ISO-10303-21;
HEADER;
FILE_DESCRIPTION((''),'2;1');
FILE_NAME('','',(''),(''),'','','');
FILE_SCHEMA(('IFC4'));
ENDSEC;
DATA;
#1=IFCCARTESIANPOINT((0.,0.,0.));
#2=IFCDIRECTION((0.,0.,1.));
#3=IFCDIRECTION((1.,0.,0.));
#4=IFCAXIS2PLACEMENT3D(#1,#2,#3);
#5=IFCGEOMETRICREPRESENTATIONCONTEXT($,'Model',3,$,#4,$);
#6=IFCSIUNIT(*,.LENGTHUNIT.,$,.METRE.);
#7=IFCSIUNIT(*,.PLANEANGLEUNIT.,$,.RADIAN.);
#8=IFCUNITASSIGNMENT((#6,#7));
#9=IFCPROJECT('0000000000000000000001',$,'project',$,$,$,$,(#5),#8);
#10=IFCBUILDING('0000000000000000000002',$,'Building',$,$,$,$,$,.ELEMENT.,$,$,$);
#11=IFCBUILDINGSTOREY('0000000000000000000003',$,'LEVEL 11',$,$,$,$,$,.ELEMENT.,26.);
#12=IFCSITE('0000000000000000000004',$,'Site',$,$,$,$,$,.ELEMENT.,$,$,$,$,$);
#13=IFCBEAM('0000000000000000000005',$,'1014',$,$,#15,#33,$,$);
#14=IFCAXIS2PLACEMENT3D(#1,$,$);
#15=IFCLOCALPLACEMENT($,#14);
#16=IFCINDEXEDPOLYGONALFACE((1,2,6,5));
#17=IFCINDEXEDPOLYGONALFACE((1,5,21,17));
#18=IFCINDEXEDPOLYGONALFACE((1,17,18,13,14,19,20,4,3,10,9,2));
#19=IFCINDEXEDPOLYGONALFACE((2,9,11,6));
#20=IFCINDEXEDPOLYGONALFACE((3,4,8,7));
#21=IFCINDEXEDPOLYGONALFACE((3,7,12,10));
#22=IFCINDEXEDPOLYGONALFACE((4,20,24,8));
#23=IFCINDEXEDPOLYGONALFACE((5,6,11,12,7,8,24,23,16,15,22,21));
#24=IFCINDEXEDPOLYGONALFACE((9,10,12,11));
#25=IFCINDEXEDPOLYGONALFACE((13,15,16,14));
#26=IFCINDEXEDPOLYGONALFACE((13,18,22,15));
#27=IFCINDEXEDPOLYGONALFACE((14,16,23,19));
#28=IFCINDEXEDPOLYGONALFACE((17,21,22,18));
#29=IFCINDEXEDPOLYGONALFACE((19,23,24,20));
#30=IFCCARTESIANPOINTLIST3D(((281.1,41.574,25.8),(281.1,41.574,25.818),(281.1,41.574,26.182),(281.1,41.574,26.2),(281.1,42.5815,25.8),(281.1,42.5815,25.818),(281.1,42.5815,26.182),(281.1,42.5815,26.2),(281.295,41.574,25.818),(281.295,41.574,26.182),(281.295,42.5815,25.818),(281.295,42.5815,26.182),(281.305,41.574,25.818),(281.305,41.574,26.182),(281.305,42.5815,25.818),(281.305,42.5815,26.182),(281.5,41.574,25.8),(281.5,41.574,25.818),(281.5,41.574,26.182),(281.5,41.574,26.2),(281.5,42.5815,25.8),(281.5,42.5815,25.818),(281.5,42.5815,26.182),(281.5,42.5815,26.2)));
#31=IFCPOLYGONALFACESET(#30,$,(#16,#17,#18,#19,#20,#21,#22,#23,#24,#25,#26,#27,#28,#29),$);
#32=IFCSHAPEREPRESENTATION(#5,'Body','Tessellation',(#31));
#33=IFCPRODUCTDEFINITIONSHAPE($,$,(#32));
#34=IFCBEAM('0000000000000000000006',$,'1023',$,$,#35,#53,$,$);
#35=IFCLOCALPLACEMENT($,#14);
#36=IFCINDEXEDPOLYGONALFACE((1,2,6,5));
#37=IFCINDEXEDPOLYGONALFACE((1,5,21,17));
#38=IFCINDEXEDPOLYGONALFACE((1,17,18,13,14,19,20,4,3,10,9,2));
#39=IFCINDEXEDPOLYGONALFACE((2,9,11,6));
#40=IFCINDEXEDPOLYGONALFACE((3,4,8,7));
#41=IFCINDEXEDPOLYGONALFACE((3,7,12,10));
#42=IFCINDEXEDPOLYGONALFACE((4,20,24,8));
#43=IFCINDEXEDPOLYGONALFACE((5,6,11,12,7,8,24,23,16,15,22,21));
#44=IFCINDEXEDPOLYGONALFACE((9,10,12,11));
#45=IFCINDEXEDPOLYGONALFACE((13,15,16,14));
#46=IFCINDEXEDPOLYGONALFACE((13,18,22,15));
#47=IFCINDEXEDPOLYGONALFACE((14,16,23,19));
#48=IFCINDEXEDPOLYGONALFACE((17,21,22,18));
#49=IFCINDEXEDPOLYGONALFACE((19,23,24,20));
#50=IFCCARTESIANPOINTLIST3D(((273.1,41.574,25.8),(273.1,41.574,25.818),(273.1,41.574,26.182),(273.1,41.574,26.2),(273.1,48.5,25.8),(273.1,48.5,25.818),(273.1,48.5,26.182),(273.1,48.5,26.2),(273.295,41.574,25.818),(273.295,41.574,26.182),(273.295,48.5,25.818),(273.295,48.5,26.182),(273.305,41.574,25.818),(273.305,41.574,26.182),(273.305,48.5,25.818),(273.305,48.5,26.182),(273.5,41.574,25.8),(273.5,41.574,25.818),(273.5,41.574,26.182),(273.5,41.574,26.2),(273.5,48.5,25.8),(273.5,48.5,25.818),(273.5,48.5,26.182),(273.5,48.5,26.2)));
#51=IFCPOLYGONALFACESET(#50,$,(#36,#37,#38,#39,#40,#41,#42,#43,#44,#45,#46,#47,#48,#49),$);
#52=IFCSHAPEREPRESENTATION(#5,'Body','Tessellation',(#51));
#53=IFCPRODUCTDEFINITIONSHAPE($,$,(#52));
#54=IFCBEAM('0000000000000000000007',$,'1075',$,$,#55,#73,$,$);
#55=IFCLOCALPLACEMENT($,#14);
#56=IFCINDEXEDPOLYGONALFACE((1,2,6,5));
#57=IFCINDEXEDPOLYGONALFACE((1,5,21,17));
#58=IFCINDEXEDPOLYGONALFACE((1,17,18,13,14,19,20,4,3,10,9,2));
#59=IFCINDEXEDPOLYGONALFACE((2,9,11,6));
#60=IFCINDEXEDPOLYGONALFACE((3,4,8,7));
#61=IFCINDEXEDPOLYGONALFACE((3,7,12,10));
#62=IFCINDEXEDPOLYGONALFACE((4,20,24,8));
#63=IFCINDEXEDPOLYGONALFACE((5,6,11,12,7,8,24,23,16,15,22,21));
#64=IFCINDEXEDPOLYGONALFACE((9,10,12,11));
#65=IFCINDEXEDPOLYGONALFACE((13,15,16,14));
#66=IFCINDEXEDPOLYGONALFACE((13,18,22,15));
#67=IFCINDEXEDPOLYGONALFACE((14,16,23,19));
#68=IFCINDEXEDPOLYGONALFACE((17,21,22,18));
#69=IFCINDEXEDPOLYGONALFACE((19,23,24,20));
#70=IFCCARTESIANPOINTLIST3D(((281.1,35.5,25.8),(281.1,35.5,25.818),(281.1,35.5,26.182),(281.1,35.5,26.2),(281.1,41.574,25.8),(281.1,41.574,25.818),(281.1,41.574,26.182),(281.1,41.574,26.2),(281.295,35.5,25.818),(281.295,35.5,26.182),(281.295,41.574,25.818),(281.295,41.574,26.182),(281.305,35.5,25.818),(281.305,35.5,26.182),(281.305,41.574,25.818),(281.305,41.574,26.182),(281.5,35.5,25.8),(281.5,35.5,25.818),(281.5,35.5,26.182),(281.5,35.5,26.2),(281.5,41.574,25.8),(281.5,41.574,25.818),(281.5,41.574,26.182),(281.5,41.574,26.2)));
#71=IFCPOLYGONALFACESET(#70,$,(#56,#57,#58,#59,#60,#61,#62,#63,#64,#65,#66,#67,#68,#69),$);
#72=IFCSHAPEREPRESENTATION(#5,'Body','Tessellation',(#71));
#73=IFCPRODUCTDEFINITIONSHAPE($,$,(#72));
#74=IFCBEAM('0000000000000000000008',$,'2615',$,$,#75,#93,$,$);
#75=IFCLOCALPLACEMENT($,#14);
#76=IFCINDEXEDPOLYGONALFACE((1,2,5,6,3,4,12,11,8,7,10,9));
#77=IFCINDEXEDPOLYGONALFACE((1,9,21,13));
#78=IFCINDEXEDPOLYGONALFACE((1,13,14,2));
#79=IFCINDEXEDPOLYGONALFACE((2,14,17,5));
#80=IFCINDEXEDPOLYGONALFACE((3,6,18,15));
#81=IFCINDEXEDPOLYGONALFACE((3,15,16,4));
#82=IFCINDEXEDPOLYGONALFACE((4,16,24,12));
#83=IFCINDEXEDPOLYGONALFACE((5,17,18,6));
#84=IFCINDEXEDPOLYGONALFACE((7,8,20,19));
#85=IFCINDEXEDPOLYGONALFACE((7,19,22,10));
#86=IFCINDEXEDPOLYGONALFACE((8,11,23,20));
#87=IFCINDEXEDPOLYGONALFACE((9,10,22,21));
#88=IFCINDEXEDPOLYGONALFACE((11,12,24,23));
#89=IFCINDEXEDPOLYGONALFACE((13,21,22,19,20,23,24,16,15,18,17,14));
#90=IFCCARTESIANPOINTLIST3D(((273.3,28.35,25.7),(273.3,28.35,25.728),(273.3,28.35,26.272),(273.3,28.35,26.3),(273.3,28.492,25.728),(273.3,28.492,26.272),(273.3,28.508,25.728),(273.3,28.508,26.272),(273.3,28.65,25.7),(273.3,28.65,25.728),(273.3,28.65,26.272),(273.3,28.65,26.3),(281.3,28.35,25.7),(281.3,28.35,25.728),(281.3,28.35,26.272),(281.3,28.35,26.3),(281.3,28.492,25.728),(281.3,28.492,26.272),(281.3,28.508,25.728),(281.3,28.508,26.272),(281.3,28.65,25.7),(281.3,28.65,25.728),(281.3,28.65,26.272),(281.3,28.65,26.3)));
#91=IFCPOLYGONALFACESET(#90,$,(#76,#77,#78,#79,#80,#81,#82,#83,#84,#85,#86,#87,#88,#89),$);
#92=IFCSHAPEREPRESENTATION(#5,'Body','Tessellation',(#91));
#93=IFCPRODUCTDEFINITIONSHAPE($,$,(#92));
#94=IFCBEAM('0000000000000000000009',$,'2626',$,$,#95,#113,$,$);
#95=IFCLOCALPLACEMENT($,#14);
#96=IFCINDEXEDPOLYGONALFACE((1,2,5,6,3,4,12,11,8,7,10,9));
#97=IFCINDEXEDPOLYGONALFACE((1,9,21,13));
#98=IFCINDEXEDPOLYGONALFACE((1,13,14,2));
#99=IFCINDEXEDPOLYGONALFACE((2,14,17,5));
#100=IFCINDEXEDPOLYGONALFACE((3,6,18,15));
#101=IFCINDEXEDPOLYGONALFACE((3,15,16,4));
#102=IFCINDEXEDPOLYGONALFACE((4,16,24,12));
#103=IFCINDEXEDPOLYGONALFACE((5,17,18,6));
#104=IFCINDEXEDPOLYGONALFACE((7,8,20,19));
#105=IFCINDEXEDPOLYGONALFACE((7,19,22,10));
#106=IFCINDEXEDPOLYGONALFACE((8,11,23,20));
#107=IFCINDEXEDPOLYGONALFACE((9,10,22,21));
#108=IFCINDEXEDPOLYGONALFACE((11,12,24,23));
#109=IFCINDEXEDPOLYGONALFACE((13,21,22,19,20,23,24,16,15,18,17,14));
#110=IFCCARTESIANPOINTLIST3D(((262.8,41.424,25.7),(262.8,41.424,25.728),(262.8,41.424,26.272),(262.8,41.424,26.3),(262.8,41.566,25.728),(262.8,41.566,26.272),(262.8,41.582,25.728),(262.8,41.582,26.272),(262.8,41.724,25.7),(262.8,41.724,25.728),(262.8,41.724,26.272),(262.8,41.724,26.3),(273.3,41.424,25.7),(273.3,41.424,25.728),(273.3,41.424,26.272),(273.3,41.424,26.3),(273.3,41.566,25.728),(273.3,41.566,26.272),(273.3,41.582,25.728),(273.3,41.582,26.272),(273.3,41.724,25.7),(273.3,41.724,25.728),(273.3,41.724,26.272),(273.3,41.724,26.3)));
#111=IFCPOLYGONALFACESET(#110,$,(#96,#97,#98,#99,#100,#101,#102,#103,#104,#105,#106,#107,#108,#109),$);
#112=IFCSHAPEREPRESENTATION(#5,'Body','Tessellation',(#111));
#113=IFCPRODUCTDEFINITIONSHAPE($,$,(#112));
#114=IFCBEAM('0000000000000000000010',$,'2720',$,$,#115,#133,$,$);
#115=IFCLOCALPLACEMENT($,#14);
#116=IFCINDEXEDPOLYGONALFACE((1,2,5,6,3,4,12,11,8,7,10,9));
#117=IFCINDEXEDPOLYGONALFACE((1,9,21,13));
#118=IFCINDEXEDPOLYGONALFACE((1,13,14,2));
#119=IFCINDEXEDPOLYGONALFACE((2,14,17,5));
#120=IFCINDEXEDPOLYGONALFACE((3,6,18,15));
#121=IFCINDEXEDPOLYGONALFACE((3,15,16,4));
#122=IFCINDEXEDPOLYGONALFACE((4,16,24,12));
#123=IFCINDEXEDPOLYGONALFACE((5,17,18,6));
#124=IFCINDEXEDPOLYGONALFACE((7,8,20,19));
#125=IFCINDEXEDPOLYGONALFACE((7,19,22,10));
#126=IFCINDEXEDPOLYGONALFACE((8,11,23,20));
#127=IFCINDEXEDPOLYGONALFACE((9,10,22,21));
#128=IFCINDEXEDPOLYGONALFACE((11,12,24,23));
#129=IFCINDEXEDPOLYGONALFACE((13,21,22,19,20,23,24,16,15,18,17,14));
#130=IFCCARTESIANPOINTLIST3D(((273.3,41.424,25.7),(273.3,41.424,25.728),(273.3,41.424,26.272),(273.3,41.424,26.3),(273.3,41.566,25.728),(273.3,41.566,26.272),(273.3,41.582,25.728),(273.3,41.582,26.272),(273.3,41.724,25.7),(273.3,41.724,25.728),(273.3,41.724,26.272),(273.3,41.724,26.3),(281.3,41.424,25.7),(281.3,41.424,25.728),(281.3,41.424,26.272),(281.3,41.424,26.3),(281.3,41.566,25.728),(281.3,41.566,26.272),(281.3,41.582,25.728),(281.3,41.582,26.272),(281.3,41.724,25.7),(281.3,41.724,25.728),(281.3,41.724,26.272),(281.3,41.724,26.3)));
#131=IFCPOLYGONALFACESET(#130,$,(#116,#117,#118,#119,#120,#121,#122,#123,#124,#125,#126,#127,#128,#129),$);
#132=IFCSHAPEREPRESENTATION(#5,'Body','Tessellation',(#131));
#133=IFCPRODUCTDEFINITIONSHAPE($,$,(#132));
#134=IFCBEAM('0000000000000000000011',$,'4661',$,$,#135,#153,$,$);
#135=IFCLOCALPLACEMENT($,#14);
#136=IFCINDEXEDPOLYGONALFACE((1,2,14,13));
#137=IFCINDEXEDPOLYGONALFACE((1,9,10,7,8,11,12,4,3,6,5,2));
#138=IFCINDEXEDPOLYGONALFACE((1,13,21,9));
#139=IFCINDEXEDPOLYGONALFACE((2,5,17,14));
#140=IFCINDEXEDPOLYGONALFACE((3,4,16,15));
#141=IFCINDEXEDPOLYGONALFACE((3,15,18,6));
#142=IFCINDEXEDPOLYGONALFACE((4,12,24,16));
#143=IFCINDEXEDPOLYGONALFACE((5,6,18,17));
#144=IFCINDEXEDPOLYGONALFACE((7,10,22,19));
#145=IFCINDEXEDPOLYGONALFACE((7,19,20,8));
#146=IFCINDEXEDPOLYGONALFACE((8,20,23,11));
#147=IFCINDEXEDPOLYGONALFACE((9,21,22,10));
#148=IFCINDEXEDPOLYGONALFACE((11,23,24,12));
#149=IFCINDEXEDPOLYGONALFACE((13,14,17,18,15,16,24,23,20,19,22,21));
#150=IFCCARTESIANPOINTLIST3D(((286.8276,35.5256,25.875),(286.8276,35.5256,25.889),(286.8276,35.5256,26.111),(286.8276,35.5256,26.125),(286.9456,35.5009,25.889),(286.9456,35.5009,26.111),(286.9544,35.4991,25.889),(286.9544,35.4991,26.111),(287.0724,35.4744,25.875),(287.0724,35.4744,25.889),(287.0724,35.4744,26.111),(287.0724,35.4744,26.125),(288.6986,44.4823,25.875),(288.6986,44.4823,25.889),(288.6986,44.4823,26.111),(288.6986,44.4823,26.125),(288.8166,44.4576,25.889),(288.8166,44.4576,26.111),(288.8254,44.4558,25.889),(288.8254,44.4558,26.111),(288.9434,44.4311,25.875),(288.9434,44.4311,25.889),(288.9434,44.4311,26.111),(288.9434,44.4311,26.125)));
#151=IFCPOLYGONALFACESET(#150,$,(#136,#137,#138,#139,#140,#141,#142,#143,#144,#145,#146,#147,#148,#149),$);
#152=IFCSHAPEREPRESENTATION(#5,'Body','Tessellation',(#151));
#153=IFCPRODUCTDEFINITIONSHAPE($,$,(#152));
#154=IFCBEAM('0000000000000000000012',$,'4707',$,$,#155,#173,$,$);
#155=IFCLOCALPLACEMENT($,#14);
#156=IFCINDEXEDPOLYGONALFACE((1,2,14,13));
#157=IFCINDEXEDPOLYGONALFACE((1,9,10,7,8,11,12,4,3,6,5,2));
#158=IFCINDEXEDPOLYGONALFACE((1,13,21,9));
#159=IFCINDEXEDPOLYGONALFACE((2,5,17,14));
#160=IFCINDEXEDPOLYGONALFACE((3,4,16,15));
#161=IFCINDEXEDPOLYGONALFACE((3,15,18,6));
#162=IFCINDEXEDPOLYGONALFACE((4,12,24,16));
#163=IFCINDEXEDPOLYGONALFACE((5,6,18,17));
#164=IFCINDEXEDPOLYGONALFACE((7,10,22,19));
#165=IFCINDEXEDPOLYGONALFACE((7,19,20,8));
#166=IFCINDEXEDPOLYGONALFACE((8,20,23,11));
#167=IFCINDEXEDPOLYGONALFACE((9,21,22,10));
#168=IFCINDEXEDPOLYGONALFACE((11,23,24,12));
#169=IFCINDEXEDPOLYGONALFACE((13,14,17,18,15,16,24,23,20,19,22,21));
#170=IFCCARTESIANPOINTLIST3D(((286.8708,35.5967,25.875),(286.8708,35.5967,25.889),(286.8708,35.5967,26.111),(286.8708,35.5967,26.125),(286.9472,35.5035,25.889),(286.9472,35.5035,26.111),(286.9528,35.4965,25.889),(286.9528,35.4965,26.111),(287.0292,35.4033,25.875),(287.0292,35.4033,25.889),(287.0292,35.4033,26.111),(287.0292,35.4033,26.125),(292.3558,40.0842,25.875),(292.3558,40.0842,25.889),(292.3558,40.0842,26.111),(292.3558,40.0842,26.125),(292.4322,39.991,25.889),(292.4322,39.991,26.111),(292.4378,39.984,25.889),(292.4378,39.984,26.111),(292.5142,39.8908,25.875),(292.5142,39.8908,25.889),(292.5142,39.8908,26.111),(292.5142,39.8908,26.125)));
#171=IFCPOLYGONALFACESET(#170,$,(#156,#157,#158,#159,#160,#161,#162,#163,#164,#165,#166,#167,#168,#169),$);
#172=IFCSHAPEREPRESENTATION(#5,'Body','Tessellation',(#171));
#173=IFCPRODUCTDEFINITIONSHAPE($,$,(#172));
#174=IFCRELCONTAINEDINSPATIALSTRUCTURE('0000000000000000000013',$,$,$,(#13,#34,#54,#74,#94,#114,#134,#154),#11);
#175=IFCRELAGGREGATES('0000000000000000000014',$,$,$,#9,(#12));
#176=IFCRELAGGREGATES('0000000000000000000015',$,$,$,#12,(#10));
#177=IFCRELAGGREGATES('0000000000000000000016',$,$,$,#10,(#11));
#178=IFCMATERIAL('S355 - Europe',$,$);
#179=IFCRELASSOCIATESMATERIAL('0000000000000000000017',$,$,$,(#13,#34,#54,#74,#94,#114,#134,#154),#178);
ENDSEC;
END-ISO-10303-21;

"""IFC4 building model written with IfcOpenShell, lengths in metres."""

from ifc_helpers import new_model, si_unit, frame, origin_with_axes, origin_2d_with_axis, place, context, project, spatial, i_section, extrude, material, material_profile, profile_set, profile_usage, element, save


model = new_model("IFC4")

# Units and contexts
model_context = context("Model", 3, world=origin_with_axes())
ifc_project = project(units=[si_unit("LENGTHUNIT", "METRE"), si_unit("PLANEANGLEUNIT", "RADIAN")], contexts=[model_context])

# Site, building, storey
site = spatial("IfcSite", under=ifc_project, Name="Site", CompositionType="ELEMENT")
building = spatial("IfcBuilding", under=site, Name="Building", CompositionType="ELEMENT")
storey = spatial("IfcBuildingStorey", under=building, Name="LEVEL 11", CompositionType="ELEMENT", Elevation=26.0)

# Shared definitions
ifc_material = material(Name="S355 - Europe")

# Beams
ifc_material_profile_1 = material_profile(ifc_material, i_section(OverallWidth=0.4, OverallDepth=0.4, WebThickness=0.01, FlangeThickness=0.018, at=origin_2d_with_axis()))
ifc_profile_set_1 = profile_set([ifc_material_profile_1])
ifc_profile_usage_1 = profile_usage(ifc_profile_set_1, cardinal=10)
beam_1_placement = place(None, frame((281.3, 42.5815, 26.0), z_axis=(0.0, -1.0, 0.0), x_axis=(1.0, 0.0, 0.0)))
element("IfcBeam", 1, at=beam_1_placement, inside=storey, material=ifc_profile_usage_1, Name="1014", context=model_context, shape_type="SweptSolid", body=[
    extrude(i_section(OverallWidth=0.4, OverallDepth=0.4, WebThickness=0.01, FlangeThickness=0.018, at=origin_2d_with_axis()), origin_with_axes(), (0.0, 0.0, 1.0), 1.0075),
])
ifc_material_profile_2 = material_profile(ifc_material, i_section(OverallWidth=0.4, OverallDepth=0.4, WebThickness=0.01, FlangeThickness=0.018, at=origin_2d_with_axis()))
ifc_profile_set_2 = profile_set([ifc_material_profile_2])
ifc_profile_usage_2 = profile_usage(ifc_profile_set_2, cardinal=10)
beam_2_placement = place(None, frame((273.3, 41.574, 26.0), z_axis=(0.0, 1.0, 0.0), x_axis=(-1.0, 0.0, 0.0)))
element("IfcBeam", 2, at=beam_2_placement, inside=storey, material=ifc_profile_usage_2, Name="1023", context=model_context, shape_type="SweptSolid", body=[
    extrude(i_section(OverallWidth=0.4, OverallDepth=0.4, WebThickness=0.01, FlangeThickness=0.018, at=origin_2d_with_axis()), origin_with_axes(), (0.0, 0.0, 1.0), 6.926),
])
ifc_material_profile_3 = material_profile(ifc_material, i_section(OverallWidth=0.4, OverallDepth=0.4, WebThickness=0.01, FlangeThickness=0.018, at=origin_2d_with_axis()))
ifc_profile_set_3 = profile_set([ifc_material_profile_3])
ifc_profile_usage_3 = profile_usage(ifc_profile_set_3, cardinal=10)
beam_3_placement = place(None, frame((281.3, 41.574, 26.0), z_axis=(0.0, -1.0, 0.0), x_axis=(1.0, 0.0, 0.0)))
element("IfcBeam", 3, at=beam_3_placement, inside=storey, material=ifc_profile_usage_3, Name="1075", context=model_context, shape_type="SweptSolid", body=[
    extrude(i_section(OverallWidth=0.4, OverallDepth=0.4, WebThickness=0.01, FlangeThickness=0.018, at=origin_2d_with_axis()), origin_with_axes(), (0.0, 0.0, 1.0), 6.074),
])
ifc_material_profile_4 = material_profile(ifc_material, i_section(OverallWidth=0.3, OverallDepth=0.6, WebThickness=0.016, FlangeThickness=0.028, at=origin_2d_with_axis()))
ifc_profile_set_4 = profile_set([ifc_material_profile_4])
ifc_profile_usage_4 = profile_usage(ifc_profile_set_4, cardinal=10)
beam_4_placement = place(None, frame((281.3, 28.5, 26.0), z_axis=(-1.0, 0.0, 0.0), x_axis=(0.0, -1.0, 0.0)))
element("IfcBeam", 4, at=beam_4_placement, inside=storey, material=ifc_profile_usage_4, Name="2615", context=model_context, shape_type="SweptSolid", body=[
    extrude(i_section(OverallWidth=0.3, OverallDepth=0.6, WebThickness=0.016, FlangeThickness=0.028, at=origin_2d_with_axis()), origin_with_axes(), (0.0, 0.0, 1.0), 8.0),
])
ifc_material_profile_5 = material_profile(ifc_material, i_section(OverallWidth=0.3, OverallDepth=0.6, WebThickness=0.016, FlangeThickness=0.028, at=origin_2d_with_axis()))
ifc_profile_set_5 = profile_set([ifc_material_profile_5])
ifc_profile_usage_5 = profile_usage(ifc_profile_set_5, cardinal=10)
beam_5_placement = place(None, frame((273.3, 41.574, 26.0), z_axis=(-1.0, 0.0, 0.0), x_axis=(0.0, -1.0, 0.0)))
element("IfcBeam", 5, at=beam_5_placement, inside=storey, material=ifc_profile_usage_5, Name="2626", context=model_context, shape_type="SweptSolid", body=[
    extrude(i_section(OverallWidth=0.3, OverallDepth=0.6, WebThickness=0.016, FlangeThickness=0.028, at=origin_2d_with_axis()), origin_with_axes(), (0.0, 0.0, 1.0), 10.5),
])
ifc_material_profile_6 = material_profile(ifc_material, i_section(OverallWidth=0.3, OverallDepth=0.6, WebThickness=0.016, FlangeThickness=0.028, at=origin_2d_with_axis()))
ifc_profile_set_6 = profile_set([ifc_material_profile_6])
ifc_profile_usage_6 = profile_usage(ifc_profile_set_6, cardinal=10)
beam_6_placement = place(None, frame((281.3, 41.574, 26.0), z_axis=(-1.0, 0.0, 0.0), x_axis=(0.0, -1.0, 0.0)))
element("IfcBeam", 6, at=beam_6_placement, inside=storey, material=ifc_profile_usage_6, Name="2720", context=model_context, shape_type="SweptSolid", body=[
    extrude(i_section(OverallWidth=0.3, OverallDepth=0.6, WebThickness=0.016, FlangeThickness=0.028, at=origin_2d_with_axis()), origin_with_axes(), (0.0, 0.0, 1.0), 8.0),
])
ifc_material_profile_7 = material_profile(ifc_material, i_section(OverallWidth=0.25, OverallDepth=0.25, WebThickness=0.009, FlangeThickness=0.014, at=origin_2d_with_axis()))
ifc_profile_set_7 = profile_set([ifc_material_profile_7])
ifc_profile_usage_7 = profile_usage(ifc_profile_set_7, cardinal=10)
beam_7_placement = place(None, frame((286.95, 35.5, 26.0), z_axis=(0.20448, 0.978871, 0.0), x_axis=(-0.978871, 0.20448, 0.0)))
element("IfcBeam", 7, at=beam_7_placement, inside=storey, material=ifc_profile_usage_7, Name="4661", context=model_context, shape_type="SweptSolid", body=[
    extrude(i_section(OverallWidth=0.25, OverallDepth=0.25, WebThickness=0.009, FlangeThickness=0.014, at=origin_2d_with_axis()), origin_with_axes(), (0.0, 0.0, 1.0), 9.15),
])
ifc_material_profile_8 = material_profile(ifc_material, i_section(OverallWidth=0.25, OverallDepth=0.25, WebThickness=0.009, FlangeThickness=0.014, at=origin_2d_with_axis()))
ifc_profile_set_8 = profile_set([ifc_material_profile_8])
ifc_profile_usage_8 = profile_usage(ifc_profile_set_8, cardinal=10)
beam_8_placement = place(None, frame((286.95, 35.5, 26.0), z_axis=(0.773973, 0.633219, 0.0), x_axis=(-0.633219, 0.773973, 0.0)))
element("IfcBeam", 8, at=beam_8_placement, inside=storey, material=ifc_profile_usage_8, Name="4707", context=model_context, shape_type="SweptSolid", body=[
    extrude(i_section(OverallWidth=0.25, OverallDepth=0.25, WebThickness=0.009, FlangeThickness=0.014, at=origin_2d_with_axis()), origin_with_axes(), (0.0, 0.0, 1.0), 7.0868),
])

save(model, "model.ifc")
